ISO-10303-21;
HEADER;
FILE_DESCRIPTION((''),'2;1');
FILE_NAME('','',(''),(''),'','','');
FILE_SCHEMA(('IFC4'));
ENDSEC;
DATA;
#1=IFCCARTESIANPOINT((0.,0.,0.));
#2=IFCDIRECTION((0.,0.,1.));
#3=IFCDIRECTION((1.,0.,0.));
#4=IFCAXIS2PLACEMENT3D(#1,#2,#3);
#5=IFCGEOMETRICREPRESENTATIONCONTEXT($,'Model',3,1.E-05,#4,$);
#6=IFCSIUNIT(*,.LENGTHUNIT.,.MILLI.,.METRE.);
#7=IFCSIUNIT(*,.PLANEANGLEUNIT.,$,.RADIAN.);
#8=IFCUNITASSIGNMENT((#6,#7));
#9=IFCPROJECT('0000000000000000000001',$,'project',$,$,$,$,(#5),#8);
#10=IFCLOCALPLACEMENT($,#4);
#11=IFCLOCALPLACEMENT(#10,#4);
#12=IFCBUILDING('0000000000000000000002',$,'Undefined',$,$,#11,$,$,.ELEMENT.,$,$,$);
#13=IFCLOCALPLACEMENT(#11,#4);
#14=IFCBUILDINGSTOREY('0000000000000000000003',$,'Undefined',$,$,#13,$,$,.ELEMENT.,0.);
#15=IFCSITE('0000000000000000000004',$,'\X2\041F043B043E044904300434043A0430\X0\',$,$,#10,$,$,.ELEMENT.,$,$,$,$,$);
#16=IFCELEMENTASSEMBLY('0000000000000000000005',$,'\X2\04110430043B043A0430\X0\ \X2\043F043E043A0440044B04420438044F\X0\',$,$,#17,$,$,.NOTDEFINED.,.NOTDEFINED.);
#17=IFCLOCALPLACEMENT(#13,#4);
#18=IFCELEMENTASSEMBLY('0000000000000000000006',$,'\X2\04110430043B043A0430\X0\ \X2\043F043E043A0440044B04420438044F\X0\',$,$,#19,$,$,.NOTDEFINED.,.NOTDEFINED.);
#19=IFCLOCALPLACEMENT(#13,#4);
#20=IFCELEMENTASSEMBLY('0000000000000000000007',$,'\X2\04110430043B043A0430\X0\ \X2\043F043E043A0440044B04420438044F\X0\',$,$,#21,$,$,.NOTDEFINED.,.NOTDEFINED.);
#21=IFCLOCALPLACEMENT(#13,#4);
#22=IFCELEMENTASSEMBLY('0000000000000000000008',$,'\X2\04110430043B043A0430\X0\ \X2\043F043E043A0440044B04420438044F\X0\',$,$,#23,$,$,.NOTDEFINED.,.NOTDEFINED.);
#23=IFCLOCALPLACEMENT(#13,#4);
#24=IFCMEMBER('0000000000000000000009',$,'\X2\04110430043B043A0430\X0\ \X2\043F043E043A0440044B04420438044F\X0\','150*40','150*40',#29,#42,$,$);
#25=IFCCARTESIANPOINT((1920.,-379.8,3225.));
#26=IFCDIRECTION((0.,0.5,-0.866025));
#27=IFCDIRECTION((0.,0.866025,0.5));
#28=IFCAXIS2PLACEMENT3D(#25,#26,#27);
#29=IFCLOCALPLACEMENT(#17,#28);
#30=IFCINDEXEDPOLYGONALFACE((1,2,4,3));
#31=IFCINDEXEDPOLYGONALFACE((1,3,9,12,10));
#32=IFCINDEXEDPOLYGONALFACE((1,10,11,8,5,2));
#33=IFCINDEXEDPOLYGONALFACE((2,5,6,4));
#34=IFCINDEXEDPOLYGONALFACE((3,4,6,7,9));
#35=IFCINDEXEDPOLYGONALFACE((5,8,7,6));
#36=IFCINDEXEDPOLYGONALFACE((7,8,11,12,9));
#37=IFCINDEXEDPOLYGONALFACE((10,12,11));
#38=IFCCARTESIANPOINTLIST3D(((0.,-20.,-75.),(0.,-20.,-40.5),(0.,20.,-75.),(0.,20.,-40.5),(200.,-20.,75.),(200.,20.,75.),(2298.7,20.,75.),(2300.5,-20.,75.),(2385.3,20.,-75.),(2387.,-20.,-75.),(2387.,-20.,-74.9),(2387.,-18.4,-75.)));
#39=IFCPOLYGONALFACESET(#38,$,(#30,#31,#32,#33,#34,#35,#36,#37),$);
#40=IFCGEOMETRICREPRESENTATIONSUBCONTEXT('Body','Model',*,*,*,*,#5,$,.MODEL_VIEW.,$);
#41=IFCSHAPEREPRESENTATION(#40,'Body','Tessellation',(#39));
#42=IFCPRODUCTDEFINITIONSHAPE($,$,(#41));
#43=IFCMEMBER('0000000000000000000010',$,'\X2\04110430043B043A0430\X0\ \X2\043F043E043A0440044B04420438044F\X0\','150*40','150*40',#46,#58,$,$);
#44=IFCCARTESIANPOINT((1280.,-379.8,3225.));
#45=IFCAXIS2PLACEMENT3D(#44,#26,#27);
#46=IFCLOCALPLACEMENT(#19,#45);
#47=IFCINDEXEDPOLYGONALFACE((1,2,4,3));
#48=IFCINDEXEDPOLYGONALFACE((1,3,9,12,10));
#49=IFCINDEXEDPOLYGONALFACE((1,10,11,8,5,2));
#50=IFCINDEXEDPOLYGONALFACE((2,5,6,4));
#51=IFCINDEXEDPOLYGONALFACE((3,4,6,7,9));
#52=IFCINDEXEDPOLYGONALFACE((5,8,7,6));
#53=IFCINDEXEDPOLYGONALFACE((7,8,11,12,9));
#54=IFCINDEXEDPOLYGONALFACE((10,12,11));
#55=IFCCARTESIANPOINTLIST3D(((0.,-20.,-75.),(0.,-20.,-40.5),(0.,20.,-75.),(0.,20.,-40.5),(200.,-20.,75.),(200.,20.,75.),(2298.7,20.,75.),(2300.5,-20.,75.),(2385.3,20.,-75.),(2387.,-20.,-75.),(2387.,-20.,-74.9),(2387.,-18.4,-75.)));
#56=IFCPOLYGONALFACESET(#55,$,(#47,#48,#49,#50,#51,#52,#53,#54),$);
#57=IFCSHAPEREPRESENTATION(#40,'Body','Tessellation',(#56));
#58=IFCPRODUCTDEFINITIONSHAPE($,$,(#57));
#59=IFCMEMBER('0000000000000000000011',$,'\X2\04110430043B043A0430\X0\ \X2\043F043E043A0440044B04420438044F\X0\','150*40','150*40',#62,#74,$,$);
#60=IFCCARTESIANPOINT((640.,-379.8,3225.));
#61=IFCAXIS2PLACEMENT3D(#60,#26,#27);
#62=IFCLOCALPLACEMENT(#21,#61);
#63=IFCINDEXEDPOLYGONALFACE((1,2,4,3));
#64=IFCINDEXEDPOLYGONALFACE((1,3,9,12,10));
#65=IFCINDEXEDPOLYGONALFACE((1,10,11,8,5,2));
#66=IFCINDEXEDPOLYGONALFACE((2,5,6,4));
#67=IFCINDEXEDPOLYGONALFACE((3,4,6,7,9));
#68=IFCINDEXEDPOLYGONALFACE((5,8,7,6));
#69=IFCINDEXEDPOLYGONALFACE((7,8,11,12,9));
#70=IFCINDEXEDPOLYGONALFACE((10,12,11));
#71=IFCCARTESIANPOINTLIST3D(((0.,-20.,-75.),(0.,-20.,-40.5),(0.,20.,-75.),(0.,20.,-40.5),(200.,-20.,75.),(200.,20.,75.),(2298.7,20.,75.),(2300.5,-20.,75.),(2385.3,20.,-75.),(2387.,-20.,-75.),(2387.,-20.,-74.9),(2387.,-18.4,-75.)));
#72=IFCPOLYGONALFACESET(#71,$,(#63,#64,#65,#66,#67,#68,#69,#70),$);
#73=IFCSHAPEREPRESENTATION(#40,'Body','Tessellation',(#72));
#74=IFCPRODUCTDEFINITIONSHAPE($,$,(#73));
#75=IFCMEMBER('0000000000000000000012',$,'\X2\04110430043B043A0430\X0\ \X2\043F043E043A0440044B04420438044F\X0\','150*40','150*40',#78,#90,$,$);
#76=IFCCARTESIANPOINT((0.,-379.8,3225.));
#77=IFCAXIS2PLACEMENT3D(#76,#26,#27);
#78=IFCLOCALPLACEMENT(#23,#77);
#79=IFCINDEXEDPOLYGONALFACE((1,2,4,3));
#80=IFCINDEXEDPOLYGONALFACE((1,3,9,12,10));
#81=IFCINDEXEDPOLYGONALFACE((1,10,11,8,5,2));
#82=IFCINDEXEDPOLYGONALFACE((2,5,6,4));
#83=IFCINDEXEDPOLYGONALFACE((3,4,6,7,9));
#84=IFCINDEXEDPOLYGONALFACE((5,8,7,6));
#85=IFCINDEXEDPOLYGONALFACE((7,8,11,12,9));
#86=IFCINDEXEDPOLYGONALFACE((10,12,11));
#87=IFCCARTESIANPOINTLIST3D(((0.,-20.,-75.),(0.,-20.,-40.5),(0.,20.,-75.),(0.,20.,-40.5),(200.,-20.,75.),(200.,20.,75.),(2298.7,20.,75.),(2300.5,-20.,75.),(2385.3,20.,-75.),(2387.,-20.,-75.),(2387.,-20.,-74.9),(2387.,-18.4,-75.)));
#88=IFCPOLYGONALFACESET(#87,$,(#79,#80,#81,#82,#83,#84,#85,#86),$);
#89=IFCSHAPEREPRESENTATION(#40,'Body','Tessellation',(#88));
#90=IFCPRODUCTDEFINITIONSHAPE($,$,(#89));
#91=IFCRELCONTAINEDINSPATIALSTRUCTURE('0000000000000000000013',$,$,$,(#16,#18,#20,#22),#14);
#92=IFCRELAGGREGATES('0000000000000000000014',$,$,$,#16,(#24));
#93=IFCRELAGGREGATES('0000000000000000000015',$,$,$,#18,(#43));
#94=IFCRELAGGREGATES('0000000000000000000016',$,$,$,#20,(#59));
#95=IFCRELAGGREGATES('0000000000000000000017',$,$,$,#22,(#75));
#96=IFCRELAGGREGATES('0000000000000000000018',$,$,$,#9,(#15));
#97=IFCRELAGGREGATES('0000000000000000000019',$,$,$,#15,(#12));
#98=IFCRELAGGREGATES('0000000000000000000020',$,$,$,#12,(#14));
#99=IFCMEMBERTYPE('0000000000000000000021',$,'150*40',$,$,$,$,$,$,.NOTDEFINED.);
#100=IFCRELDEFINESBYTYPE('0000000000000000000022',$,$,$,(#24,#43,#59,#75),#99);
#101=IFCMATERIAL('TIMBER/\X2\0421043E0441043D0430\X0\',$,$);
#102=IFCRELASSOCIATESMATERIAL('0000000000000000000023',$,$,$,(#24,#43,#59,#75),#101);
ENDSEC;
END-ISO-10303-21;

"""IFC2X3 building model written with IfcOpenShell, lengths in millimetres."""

from ifc_helpers import new_model, si_unit, frame, origin_with_axes, origin_2d_with_axis, place, context, subcontext, project, spatial, rectangle, extrude, boolean, halfspace, material, type_object, element, aggregate, save


model = new_model("IFC2X3")

# Units and contexts
model_context = context("Model", 3, precision=1e-05, world=origin_with_axes())
body_context = subcontext(model_context, "Body", "Model", "MODEL_VIEW")
ifc_project = project(units=[si_unit("LENGTHUNIT", "METRE", prefix="MILLI"), si_unit("PLANEANGLEUNIT", "RADIAN")], contexts=[model_context])

# Site, building, storey
site_placement = place(None, origin_with_axes())
site = spatial("IfcSite", under=ifc_project, at=site_placement, Name="Площадка", CompositionType="ELEMENT")
building_placement = place(site_placement, origin_with_axes())
building = spatial("IfcBuilding", under=site, at=building_placement, Name="Undefined", CompositionType="ELEMENT")
storey_placement = place(building_placement, origin_with_axes())
storey = spatial("IfcBuildingStorey", under=building, at=storey_placement, Name="Undefined", CompositionType="ELEMENT", Elevation=0.0)

# Element assembly
ifc_material_1 = material(Name="TIMBER/Сосна")
assembly_1_placement = place(storey_placement, origin_with_axes())
assembly_1 = element("IfcElementAssembly", 1, at=assembly_1_placement, inside=storey, Name="Балка покрытия", AssemblyPlace="NOTDEFINED", PredefinedType="NOTDEFINED")

# Element assemblies
assembly_2_placement = place(storey_placement, origin_with_axes())
assembly_2 = element("IfcElementAssembly", 2, at=assembly_2_placement, inside=storey, Name="Балка покрытия", AssemblyPlace="NOTDEFINED", PredefinedType="NOTDEFINED")
assembly_3_placement = place(storey_placement, origin_with_axes())
assembly_3 = element("IfcElementAssembly", 3, at=assembly_3_placement, inside=storey, Name="Балка покрытия", AssemblyPlace="NOTDEFINED", PredefinedType="NOTDEFINED")
assembly_4_placement = place(storey_placement, origin_with_axes())
assembly_4 = element("IfcElementAssembly", 4, at=assembly_4_placement, inside=storey, Name="Балка покрытия", AssemblyPlace="NOTDEFINED", PredefinedType="NOTDEFINED")

# Members
member_type = type_object("IfcMemberType", Name="150*40", PredefinedType="NOTDEFINED")
member_1_placement = place(assembly_1_placement, frame((1920.0, -379.8, 3225.0), z_axis=(0.0, 0.5, -0.866025), x_axis=(0.0, 0.866025, 0.5)))
member_1 = element("IfcMember", 5, at=member_1_placement, type_object=member_type, material=ifc_material_1, Name="Балка покрытия", Description="150*40", ObjectType="150*40", context=body_context, shape_type="CSG", body=[
    boolean("DIFFERENCE", boolean("DIFFERENCE", extrude(rectangle(XDim=40.0, YDim=150.0, at=origin_2d_with_axis()), frame((2387.0, 0.0, 0.0), z_axis=(-1.0, 0.0, 0.0), x_axis=(0.0, -1.0, 0.0)), (0.0, 0.0, 1.0), 2387.0), extrude(rectangle(XDim=40.0, YDim=150.0, at=origin_2d_with_axis()), frame((3513.2, 0.0, 2074.5), z_axis=(-0.866025, 0.0, -0.5), x_axis=(0.0, -1.0, 0.0)), (0.0, 0.0, 1.0), 4100.0)), halfspace(frame((2298.7, 20.0, 75.0), z_axis=(0.86539, 0.038305, 0.499633), x_axis=(0.5, 0.0, -0.866025)), False)),
])
aggregate(assembly_1, [member_1])
member_2_placement = place(assembly_2_placement, frame((1280.0, -379.8, 3225.0), z_axis=(0.0, 0.5, -0.866025), x_axis=(0.0, 0.866025, 0.5)))
member_2 = element("IfcMember", 6, at=member_2_placement, type_object=member_type, material=ifc_material_1, Name="Балка покрытия", Description="150*40", ObjectType="150*40", context=body_context, shape_type="CSG", body=[
    boolean("DIFFERENCE", boolean("DIFFERENCE", extrude(rectangle(XDim=40.0, YDim=150.0, at=origin_2d_with_axis()), frame((2387.0, 0.0, 0.0), z_axis=(-1.0, 0.0, 0.0), x_axis=(0.0, -1.0, 0.0)), (0.0, 0.0, 1.0), 2387.0), extrude(rectangle(XDim=40.0, YDim=150.0, at=origin_2d_with_axis()), frame((3513.2, 0.0, 2074.5), z_axis=(-0.866025, 0.0, -0.5), x_axis=(0.0, -1.0, 0.0)), (0.0, 0.0, 1.0), 4100.0)), halfspace(frame((2298.7, 20.0, 75.0), z_axis=(0.86539, 0.038305, 0.499633), x_axis=(0.5, 0.0, -0.866025)), False)),
])
aggregate(assembly_2, [member_2])
member_3_placement = place(assembly_3_placement, frame((640.0, -379.8, 3225.0), z_axis=(0.0, 0.5, -0.866025), x_axis=(0.0, 0.866025, 0.5)))
member_3 = element("IfcMember", 7, at=member_3_placement, type_object=member_type, material=ifc_material_1, Name="Балка покрытия", Description="150*40", ObjectType="150*40", context=body_context, shape_type="CSG", body=[
    boolean("DIFFERENCE", boolean("DIFFERENCE", extrude(rectangle(XDim=40.0, YDim=150.0, at=origin_2d_with_axis()), frame((2387.0, 0.0, 0.0), z_axis=(-1.0, 0.0, 0.0), x_axis=(0.0, -1.0, 0.0)), (0.0, 0.0, 1.0), 2387.0), extrude(rectangle(XDim=40.0, YDim=150.0, at=origin_2d_with_axis()), frame((3513.2, 0.0, 2074.5), z_axis=(-0.866025, 0.0, -0.5), x_axis=(0.0, -1.0, 0.0)), (0.0, 0.0, 1.0), 4100.0)), halfspace(frame((2298.7, 20.0, 75.0), z_axis=(0.86539, 0.038305, 0.499633), x_axis=(0.5, 0.0, -0.866025)), False)),
])
aggregate(assembly_3, [member_3])
member_4_placement = place(assembly_4_placement, frame((0.0, -379.8, 3225.0), z_axis=(0.0, 0.5, -0.866025), x_axis=(0.0, 0.866025, 0.5)))
member_4 = element("IfcMember", 8, at=member_4_placement, type_object=member_type, material=ifc_material_1, Name="Балка покрытия", Description="150*40", ObjectType="150*40", context=body_context, shape_type="CSG", body=[
    boolean("DIFFERENCE", boolean("DIFFERENCE", extrude(rectangle(XDim=40.0, YDim=150.0, at=origin_2d_with_axis()), frame((2387.0, 0.0, 0.0), z_axis=(-1.0, 0.0, 0.0), x_axis=(0.0, -1.0, 0.0)), (0.0, 0.0, 1.0), 2387.0), extrude(rectangle(XDim=40.0, YDim=150.0, at=origin_2d_with_axis()), frame((3513.2, 0.0, 2074.5), z_axis=(-0.866025, 0.0, -0.5), x_axis=(0.0, -1.0, 0.0)), (0.0, 0.0, 1.0), 4100.0)), halfspace(frame((2298.7, 20.0, 75.0), z_axis=(0.86539, 0.038305, 0.499633), x_axis=(0.5, 0.0, -0.866025)), False)),
])
aggregate(assembly_4, [member_4])

save(model, "model.ifc")
